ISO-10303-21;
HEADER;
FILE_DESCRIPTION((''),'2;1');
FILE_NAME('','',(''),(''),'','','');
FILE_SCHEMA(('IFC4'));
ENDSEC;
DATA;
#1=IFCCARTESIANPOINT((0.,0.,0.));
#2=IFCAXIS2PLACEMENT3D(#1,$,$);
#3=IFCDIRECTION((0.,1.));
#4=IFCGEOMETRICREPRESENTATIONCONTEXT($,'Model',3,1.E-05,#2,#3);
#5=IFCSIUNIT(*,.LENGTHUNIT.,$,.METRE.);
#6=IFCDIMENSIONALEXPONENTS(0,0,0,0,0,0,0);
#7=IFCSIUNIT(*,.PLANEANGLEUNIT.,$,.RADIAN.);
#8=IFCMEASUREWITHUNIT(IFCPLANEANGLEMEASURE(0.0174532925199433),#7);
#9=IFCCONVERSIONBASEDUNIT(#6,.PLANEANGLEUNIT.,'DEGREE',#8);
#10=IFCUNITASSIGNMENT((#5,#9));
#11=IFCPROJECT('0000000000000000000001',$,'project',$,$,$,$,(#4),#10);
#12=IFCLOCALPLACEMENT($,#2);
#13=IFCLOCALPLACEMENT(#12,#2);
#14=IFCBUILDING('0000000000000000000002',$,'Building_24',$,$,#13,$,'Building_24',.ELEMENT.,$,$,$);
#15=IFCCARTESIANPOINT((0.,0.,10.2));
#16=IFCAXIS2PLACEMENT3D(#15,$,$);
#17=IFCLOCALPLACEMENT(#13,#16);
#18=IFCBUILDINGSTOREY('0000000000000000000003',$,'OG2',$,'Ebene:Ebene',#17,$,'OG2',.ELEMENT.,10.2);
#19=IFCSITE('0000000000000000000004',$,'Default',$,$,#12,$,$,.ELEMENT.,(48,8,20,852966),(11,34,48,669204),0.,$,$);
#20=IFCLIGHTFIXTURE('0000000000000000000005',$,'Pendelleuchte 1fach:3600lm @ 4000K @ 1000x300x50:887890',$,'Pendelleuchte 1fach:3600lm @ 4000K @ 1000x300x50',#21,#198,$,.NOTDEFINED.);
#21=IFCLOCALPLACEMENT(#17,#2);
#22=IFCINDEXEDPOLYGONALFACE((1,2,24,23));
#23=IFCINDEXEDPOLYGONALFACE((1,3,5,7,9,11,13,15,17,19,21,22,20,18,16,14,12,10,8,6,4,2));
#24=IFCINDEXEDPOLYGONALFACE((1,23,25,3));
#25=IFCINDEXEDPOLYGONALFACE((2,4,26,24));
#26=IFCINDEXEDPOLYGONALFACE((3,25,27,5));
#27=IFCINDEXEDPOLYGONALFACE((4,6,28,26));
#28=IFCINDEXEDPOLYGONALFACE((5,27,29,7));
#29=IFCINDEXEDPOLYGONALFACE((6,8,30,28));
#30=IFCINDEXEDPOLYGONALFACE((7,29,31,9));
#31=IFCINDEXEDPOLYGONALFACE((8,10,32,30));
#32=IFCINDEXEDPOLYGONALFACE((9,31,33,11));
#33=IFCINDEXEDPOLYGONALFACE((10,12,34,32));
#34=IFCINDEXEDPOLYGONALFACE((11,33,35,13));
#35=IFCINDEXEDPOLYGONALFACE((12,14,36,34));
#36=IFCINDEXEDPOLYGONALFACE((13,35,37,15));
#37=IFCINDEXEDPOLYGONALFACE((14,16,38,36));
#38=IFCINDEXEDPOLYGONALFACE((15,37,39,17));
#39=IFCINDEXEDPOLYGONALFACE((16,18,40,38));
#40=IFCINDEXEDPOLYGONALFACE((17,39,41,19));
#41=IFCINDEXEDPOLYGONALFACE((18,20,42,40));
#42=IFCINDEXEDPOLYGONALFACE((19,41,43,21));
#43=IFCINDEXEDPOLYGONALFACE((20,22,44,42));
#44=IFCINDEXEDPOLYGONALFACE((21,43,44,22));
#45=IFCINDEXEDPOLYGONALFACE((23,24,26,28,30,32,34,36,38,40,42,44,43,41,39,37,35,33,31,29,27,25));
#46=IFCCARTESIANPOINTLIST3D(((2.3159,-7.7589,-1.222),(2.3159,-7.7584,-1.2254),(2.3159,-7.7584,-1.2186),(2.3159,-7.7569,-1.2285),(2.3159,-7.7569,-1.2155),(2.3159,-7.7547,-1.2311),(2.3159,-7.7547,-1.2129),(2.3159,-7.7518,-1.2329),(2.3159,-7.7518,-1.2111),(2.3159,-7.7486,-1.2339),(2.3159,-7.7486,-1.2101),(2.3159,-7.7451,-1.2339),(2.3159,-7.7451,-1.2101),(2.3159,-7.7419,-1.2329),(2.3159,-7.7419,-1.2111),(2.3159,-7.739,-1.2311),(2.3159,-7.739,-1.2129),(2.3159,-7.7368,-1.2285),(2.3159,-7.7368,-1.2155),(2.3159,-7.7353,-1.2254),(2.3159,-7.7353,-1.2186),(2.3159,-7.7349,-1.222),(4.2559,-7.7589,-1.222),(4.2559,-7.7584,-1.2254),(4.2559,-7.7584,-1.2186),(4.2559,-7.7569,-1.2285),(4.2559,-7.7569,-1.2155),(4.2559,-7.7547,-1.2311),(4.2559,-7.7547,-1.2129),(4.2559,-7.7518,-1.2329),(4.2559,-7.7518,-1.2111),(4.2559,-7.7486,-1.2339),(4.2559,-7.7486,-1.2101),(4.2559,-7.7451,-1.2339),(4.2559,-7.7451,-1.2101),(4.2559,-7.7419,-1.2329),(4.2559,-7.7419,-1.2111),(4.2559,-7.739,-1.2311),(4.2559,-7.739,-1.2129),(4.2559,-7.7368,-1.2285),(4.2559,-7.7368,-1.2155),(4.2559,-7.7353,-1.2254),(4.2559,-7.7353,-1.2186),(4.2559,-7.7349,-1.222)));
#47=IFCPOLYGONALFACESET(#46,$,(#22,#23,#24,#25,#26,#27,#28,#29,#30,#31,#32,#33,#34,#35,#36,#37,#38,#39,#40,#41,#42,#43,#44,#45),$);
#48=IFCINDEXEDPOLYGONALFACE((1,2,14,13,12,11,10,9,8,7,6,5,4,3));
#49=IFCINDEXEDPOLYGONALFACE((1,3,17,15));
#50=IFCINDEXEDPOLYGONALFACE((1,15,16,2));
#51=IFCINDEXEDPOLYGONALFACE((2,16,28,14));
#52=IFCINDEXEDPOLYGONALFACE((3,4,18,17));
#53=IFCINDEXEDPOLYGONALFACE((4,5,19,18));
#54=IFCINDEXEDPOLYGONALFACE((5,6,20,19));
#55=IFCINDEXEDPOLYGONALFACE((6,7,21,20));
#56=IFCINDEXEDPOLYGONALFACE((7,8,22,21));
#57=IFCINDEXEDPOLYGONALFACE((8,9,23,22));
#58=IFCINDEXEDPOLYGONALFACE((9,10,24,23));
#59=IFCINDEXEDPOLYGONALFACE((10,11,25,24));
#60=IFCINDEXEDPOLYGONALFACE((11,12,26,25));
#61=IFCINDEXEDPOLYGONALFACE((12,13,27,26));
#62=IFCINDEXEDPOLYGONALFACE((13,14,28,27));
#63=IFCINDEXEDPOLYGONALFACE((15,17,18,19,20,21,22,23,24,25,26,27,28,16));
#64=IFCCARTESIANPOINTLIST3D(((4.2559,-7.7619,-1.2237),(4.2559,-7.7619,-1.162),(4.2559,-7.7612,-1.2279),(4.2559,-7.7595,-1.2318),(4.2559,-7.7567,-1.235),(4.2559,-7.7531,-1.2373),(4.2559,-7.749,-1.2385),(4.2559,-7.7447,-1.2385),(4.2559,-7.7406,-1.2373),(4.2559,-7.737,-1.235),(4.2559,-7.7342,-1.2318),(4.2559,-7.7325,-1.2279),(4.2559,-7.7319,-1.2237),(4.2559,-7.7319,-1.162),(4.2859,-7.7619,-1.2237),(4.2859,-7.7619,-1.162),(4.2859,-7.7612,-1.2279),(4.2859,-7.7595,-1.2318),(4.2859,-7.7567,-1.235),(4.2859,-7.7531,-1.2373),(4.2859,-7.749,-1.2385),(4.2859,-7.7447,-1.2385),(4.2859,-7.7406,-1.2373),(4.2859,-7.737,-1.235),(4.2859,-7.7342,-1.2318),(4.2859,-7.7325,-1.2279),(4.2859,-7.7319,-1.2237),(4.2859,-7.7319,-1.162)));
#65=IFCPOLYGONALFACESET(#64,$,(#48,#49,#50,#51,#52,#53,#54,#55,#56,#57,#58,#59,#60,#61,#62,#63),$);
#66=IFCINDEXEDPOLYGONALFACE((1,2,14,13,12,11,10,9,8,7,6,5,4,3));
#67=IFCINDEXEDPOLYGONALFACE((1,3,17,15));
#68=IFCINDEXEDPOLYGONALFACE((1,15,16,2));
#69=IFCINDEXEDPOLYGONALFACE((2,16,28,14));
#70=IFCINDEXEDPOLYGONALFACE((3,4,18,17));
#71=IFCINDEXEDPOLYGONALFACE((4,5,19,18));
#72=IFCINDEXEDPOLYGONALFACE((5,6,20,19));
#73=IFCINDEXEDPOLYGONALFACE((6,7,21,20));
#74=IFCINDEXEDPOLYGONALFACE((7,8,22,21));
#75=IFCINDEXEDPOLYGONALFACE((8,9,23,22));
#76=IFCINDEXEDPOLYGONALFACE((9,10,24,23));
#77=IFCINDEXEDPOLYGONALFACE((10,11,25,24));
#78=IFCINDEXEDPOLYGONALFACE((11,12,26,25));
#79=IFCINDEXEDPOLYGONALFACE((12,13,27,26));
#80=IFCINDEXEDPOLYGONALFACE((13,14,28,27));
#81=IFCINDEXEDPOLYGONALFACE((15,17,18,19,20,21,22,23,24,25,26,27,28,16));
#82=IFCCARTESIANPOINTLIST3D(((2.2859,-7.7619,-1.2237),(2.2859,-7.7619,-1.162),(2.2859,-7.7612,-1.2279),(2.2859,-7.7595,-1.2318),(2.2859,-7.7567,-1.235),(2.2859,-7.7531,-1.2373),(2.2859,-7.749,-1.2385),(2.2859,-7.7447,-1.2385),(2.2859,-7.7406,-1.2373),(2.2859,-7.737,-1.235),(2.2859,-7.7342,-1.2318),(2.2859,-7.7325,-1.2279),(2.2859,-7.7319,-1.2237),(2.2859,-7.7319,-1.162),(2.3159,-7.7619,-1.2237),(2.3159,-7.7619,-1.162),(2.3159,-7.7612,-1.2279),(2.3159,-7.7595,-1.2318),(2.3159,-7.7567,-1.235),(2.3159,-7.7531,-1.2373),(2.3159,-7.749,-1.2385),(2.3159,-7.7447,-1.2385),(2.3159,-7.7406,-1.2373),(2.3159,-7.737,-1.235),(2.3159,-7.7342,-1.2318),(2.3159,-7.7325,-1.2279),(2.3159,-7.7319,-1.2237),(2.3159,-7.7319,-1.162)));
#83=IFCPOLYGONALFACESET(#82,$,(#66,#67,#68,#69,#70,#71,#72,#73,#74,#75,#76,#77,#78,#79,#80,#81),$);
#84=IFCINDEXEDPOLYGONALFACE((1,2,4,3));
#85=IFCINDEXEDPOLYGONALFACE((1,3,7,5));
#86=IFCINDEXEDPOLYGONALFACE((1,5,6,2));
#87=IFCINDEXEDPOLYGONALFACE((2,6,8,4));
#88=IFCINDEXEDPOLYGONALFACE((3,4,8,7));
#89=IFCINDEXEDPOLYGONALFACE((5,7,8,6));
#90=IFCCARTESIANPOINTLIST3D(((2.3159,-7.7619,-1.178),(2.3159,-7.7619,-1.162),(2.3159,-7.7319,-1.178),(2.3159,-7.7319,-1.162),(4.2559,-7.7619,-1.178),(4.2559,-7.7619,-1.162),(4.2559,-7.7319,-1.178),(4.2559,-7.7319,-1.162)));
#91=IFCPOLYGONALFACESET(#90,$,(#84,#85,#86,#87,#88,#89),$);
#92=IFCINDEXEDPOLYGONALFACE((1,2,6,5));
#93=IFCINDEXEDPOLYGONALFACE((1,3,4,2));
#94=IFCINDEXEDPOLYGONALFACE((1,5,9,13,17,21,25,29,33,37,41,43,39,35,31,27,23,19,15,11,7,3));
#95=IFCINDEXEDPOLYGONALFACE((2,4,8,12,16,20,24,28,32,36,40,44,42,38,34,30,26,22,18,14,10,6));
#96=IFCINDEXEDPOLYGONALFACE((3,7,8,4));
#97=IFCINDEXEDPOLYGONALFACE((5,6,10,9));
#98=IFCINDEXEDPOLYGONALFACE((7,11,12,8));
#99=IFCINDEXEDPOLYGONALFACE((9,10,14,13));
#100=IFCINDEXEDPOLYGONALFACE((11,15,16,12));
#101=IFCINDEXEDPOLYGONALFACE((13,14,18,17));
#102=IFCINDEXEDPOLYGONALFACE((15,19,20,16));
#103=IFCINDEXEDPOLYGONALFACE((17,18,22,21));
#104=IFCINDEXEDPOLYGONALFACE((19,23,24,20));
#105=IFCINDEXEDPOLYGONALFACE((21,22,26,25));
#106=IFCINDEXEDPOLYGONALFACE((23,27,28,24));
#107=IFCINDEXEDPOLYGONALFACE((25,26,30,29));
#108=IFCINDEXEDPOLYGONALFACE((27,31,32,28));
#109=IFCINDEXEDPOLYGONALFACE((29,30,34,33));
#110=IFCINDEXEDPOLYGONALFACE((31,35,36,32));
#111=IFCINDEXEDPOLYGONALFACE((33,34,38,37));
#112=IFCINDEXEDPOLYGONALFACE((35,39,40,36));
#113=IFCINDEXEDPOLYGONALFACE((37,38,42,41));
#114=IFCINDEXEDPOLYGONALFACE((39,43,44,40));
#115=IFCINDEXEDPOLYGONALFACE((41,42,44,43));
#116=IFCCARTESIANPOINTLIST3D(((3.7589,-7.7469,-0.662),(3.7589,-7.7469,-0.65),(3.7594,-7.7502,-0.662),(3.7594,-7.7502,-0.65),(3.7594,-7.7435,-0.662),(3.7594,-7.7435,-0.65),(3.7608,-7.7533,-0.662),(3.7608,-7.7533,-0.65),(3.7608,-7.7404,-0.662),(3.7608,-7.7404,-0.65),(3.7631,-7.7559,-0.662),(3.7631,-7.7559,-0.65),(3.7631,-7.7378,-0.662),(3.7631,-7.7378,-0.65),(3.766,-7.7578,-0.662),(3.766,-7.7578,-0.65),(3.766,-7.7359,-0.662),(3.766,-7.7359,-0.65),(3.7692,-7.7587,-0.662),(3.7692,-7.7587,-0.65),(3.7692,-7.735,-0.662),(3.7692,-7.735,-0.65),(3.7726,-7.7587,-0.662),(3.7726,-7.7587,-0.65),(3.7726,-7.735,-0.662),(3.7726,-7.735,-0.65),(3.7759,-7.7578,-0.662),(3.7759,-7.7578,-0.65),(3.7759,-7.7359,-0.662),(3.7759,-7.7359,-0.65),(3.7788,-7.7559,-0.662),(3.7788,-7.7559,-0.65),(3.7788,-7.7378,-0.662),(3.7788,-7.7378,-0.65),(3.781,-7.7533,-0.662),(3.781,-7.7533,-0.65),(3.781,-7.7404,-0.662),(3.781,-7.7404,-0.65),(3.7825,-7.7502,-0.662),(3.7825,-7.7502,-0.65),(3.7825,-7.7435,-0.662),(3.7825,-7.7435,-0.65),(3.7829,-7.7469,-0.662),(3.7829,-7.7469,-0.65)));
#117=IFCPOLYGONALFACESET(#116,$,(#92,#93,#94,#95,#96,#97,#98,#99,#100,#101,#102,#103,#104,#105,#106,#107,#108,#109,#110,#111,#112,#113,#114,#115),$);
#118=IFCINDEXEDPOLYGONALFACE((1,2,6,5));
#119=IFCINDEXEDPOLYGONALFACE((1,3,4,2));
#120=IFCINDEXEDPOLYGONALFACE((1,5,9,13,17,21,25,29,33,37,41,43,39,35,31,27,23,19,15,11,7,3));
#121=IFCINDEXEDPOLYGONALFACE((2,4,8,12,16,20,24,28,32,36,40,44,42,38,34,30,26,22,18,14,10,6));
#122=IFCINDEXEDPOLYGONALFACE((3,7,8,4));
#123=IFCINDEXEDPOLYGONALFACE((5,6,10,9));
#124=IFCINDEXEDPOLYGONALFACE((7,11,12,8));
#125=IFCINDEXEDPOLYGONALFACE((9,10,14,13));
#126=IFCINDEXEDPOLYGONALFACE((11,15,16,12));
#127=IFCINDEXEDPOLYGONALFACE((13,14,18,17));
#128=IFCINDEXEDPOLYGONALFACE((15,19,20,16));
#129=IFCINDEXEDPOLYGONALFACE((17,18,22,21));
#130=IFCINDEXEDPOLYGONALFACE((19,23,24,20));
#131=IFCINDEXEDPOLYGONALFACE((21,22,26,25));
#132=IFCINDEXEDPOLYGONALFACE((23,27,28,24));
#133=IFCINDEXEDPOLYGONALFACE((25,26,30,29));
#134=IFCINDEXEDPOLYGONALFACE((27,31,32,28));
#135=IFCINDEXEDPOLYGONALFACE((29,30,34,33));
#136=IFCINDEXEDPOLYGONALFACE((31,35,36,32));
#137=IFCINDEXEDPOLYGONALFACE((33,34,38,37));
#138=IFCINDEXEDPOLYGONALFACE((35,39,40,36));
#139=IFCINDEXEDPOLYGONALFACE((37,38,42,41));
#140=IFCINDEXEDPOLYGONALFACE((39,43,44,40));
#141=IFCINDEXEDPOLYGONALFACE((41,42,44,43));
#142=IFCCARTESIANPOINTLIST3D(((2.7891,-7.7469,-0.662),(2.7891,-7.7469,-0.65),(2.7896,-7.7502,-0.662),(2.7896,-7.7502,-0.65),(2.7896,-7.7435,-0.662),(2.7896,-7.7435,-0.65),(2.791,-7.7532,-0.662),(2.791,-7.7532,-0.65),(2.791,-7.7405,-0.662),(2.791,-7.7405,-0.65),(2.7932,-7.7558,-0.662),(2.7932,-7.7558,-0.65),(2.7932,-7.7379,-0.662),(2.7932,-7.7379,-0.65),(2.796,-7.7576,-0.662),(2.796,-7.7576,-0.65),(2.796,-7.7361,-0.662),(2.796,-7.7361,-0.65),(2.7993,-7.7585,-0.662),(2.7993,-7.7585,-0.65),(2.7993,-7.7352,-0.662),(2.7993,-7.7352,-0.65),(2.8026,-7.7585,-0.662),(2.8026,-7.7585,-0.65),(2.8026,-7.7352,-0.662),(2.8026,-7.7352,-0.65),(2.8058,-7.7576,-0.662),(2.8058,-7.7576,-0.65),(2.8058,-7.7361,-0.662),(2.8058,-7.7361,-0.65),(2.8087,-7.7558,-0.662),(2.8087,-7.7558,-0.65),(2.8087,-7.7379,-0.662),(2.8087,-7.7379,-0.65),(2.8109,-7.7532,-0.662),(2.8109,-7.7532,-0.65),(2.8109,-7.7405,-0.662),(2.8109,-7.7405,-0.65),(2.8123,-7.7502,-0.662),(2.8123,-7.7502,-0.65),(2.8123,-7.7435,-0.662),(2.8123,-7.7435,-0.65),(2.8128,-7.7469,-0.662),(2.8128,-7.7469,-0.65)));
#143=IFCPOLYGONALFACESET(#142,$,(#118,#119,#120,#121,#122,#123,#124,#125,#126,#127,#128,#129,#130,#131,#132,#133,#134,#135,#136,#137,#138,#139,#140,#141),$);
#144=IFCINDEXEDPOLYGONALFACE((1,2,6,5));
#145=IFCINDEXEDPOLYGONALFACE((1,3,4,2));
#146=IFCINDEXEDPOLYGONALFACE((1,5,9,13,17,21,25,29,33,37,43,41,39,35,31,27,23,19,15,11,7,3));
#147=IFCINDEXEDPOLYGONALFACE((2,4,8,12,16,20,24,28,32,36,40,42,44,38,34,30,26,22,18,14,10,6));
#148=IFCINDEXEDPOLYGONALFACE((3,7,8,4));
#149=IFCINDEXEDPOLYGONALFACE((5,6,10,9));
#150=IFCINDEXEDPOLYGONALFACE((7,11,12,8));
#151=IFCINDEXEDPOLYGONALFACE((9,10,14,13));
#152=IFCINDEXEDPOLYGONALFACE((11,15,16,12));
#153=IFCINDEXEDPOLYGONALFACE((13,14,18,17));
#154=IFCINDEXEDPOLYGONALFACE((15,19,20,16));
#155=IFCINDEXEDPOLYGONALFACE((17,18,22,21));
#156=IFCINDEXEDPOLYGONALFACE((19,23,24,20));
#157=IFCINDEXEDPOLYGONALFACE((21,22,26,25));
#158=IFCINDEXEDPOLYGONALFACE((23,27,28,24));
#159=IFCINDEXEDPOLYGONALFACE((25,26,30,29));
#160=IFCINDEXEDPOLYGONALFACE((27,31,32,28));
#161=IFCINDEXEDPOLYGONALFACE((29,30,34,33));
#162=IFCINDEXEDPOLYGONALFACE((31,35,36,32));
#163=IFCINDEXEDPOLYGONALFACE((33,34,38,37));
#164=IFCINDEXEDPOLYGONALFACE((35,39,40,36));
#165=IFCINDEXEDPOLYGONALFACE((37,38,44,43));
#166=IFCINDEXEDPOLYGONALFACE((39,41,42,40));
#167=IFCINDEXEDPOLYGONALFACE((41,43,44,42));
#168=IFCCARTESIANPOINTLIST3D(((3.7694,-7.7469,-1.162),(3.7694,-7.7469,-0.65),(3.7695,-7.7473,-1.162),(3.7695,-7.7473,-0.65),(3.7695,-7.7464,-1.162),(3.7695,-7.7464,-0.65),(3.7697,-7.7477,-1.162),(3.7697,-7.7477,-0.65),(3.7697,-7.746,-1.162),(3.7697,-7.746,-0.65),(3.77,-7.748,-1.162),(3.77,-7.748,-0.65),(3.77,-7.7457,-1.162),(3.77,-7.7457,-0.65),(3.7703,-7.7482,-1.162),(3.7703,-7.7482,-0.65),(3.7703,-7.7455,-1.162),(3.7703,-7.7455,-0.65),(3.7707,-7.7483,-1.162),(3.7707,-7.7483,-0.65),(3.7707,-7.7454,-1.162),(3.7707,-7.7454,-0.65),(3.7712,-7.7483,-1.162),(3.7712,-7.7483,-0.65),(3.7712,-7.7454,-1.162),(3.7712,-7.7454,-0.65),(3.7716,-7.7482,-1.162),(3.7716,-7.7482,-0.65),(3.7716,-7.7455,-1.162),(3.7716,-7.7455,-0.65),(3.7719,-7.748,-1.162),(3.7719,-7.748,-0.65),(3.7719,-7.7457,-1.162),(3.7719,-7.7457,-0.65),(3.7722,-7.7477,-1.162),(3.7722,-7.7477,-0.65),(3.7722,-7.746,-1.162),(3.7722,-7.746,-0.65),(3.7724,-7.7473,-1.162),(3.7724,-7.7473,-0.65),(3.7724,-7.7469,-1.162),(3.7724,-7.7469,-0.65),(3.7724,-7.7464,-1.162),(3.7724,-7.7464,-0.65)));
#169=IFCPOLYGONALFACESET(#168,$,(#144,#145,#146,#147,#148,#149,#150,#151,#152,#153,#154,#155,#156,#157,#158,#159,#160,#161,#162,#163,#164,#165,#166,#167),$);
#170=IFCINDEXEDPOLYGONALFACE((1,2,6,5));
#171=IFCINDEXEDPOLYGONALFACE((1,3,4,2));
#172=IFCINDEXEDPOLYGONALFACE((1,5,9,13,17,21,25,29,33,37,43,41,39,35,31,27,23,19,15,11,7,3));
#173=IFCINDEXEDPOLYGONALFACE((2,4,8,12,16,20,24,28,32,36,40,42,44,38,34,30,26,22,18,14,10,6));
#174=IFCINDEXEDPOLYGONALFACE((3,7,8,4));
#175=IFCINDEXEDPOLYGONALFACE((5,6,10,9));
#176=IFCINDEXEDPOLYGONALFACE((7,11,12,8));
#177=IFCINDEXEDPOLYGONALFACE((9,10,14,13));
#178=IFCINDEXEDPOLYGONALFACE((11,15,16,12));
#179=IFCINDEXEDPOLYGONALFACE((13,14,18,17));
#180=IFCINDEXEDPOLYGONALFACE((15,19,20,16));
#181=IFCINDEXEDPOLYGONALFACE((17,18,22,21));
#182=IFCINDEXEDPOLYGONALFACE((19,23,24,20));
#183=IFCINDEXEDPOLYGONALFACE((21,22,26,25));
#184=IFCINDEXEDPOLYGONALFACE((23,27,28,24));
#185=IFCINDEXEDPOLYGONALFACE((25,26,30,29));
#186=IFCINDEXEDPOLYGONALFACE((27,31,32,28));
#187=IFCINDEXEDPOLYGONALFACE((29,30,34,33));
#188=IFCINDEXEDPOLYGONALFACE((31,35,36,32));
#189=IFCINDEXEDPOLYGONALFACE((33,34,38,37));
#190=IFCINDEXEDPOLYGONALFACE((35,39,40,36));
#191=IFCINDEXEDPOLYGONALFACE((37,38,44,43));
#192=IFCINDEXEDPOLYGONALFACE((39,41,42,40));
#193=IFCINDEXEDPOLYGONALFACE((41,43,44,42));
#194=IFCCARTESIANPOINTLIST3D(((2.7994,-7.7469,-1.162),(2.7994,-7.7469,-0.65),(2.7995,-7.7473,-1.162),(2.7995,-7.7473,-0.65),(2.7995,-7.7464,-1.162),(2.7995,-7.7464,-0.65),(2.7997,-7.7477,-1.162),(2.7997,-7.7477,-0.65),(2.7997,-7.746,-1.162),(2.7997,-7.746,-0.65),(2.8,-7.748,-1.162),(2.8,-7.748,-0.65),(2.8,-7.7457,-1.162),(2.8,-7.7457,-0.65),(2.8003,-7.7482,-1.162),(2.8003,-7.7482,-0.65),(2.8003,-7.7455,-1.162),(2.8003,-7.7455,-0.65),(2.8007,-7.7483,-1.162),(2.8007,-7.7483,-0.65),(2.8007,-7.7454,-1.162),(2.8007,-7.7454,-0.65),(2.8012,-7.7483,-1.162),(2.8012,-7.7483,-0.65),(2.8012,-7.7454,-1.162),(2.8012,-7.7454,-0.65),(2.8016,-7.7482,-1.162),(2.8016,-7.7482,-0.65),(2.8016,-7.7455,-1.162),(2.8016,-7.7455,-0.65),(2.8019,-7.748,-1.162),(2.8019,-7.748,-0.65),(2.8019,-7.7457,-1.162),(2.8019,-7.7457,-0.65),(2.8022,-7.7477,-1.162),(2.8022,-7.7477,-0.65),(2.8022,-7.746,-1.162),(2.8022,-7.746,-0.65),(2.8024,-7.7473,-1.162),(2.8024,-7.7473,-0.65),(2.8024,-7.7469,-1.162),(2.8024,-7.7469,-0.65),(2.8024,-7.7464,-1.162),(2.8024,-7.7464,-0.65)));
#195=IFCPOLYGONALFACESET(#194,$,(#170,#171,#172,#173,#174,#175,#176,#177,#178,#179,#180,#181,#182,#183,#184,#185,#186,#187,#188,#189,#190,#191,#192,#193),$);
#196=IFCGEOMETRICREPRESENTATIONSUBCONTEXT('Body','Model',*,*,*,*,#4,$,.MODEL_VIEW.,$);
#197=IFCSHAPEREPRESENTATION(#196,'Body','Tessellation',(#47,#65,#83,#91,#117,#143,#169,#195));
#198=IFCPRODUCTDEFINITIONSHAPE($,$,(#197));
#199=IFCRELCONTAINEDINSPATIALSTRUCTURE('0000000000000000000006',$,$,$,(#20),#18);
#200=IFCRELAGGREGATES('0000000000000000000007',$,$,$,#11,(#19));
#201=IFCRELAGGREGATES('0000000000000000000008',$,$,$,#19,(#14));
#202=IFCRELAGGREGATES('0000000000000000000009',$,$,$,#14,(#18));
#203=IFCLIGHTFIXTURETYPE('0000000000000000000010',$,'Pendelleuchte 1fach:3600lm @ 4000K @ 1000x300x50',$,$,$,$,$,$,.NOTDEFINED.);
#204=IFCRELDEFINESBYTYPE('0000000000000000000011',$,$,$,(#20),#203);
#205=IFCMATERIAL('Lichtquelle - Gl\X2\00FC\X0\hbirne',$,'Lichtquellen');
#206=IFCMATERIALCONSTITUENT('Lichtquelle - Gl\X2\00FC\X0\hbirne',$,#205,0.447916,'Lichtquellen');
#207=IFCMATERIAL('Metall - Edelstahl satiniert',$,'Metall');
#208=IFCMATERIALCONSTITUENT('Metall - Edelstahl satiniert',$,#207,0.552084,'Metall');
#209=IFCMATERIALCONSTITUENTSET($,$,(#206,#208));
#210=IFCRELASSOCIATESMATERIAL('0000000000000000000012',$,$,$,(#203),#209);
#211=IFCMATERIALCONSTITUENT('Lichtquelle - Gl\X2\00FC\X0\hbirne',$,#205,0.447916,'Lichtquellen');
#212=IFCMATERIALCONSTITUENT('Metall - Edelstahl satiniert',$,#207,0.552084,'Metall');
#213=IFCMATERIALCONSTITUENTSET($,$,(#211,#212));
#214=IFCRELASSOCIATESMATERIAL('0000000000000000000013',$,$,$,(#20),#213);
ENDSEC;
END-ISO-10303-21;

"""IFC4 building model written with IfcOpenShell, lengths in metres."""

from ifc_helpers import new_model, entity, si_unit, converted_unit, direction, frame, origin, place, context, subcontext, project, spatial, line, arc, indexed_curve, outline, extrude, source, transform, mapped, material, constituent, constituent_set, type_object, type_shapes, element, save


model = new_model("IFC4")

# Units and contexts
model_context = context("Model", 3, precision=1e-05, world=origin(), true_north=direction((0.0, 1.0)))
body_context = subcontext(model_context, "Body", "Model", "MODEL_VIEW")
ifc_project = project(units=[si_unit("LENGTHUNIT", "METRE"), converted_unit("PLANEANGLEUNIT", "DEGREE", entity("IfcPlaneAngleMeasure", 0.0174532925199433), si_unit("PLANEANGLEUNIT", "RADIAN"), dimensions=[0, 0, 0, 0, 0, 0, 0])], contexts=[model_context])

# Site, building, storey
site_placement = place(None, origin())
site = spatial("IfcSite", under=ifc_project, at=site_placement, Name="Default", CompositionType="ELEMENT", RefLatitude=(48, 8, 20, 852966), RefLongitude=(11, 34, 48, 669204), RefElevation=0.0)
building_placement = place(site_placement, origin())
building = spatial("IfcBuilding", under=site, at=building_placement, Name="Building_24", LongName="Building_24", CompositionType="ELEMENT")
storey_placement = place(building_placement, frame((0.0, 0.0, 10.2)))
storey = spatial("IfcBuildingStorey", under=building, at=storey_placement, Name="OG2", ObjectType="Ebene:Ebene", LongName="OG2", CompositionType="ELEMENT", Elevation=10.2)

# Light fixture
ifc_material_1 = material(Name="Lichtquelle - Glühbirne", Category="Lichtquellen")
ifc_material_2 = material(Name="Metall - Edelstahl satiniert", Category="Metall")
ifc_constituent_1 = constituent(ifc_material_1, Name="Lichtquelle - Glühbirne", Category="Lichtquellen", fraction=0.447916)
ifc_constituent_2 = constituent(ifc_material_2, Name="Metall - Edelstahl satiniert", Category="Metall", fraction=0.552084)
ifc_constituent_set_1 = constituent_set(constituents=[ifc_constituent_1, ifc_constituent_2])
light_fixture_type_1 = type_object("IfcLightFixtureType", Name="Pendelleuchte 1fach:3600lm @ 4000K @ 1000x300x50", PredefinedType="NOTDEFINED", material=ifc_constituent_set_1)
shared_shape_1 = source(origin(), body_context, "Body", "SweptSolid", [
    extrude(outline(indexed_curve([(-0.012, 0.0), (0.0, -0.012), (0.012, 0.0), (0.0, 0.012)], segments=[arc(1, 2, 3), arc(3, 4, 1)], self_intersect=False)), frame((-0.97, 0.0, -0.572), z_axis=(1.0, 0.0, 0.0), x_axis=(0.0, 1.0, 0.0)), (0.0, 0.0, 1.0), 1.94),
    extrude(outline(indexed_curve([(-0.0308, -0.015), (0.0308, -0.015), (0.0308, 0.015), (-0.0308, 0.015), (-0.0458, 0.0)], segments=[line(1, 2, 3, 4), arc(4, 5, 1)], self_intersect=False)), frame((0.97, 0.0, -0.5428), z_axis=(1.0, 0.0, 0.0), x_axis=(0.0, 0.0, 1.0)), (0.0, 0.0, 1.0), 0.03),
    extrude(outline(indexed_curve([(-0.0308, -0.015), (0.0308, -0.015), (0.0308, 0.015), (-0.0308, 0.015), (-0.0458, 0.0)], segments=[line(1, 2, 3, 4), arc(4, 5, 1)], self_intersect=False)), frame((-1.0, 0.0, -0.5428), z_axis=(1.0, 0.0, 0.0), x_axis=(0.0, 0.0, 1.0)), (0.0, 0.0, 1.0), 0.03),
    extrude(outline(indexed_curve([(-0.97, -0.015), (0.97, -0.015), (0.97, 0.015), (-0.97, 0.015), (-0.97, -0.015)], self_intersect=False)), frame((0.0, 0.0, -0.528), z_axis=(0.0, 0.0, 1.0), x_axis=(-1.0, 0.0, 0.0)), (0.0, 0.0, 1.0), 0.016),
    extrude(outline(indexed_curve([(-0.012, 0.0), (0.0, -0.012), (0.012, 0.0), (0.0, 0.012)], segments=[arc(1, 2, 3), arc(3, 4, 1)], self_intersect=False)), frame((0.485, 0.0, -0.012)), (0.0, 0.0, 1.0), 0.012),
    extrude(outline(indexed_curve([(-0.0118, 0.0), (0.0, -0.0118), (0.0118, 0.0), (0.0, 0.0118)], segments=[arc(1, 2, 3), arc(3, 4, 1)], self_intersect=False)), frame((-0.485, 0.0, -0.012)), (0.0, 0.0, 1.0), 0.012),
    extrude(outline(indexed_curve([(-0.0015, 0.0), (0.0, -0.0015), (0.0015, 0.0), (0.0, 0.0015)], segments=[arc(1, 2, 3), arc(3, 4, 1)], self_intersect=False)), frame((0.485, 0.0, -0.512)), (0.0, 0.0, 1.0), 0.512),
    extrude(outline(indexed_curve([(-0.0015, 0.0), (0.0, -0.0015), (0.0015, 0.0), (0.0, 0.0015)], segments=[arc(1, 2, 3), arc(3, 4, 1)], self_intersect=False)), frame((-0.485, 0.0, -0.512)), (0.0, 0.0, 1.0), 0.512),
])
type_shapes(light_fixture_type_1, [shared_shape_1])
ifc_constituent_3 = constituent(ifc_material_1, Name="Lichtquelle - Glühbirne", Category="Lichtquellen", fraction=0.447916)
ifc_constituent_4 = constituent(ifc_material_2, Name="Metall - Edelstahl satiniert", Category="Metall", fraction=0.552084)
ifc_constituent_set_2 = constituent_set(constituents=[ifc_constituent_3, ifc_constituent_4])
light_fixture_1_placement = place(storey_placement, frame((3.2859, -7.7469, -0.65)))
element("IfcLightFixture", 1, at=light_fixture_1_placement, inside=storey, type_object=light_fixture_type_1, material=ifc_constituent_set_2, Name="Pendelleuchte 1fach:3600lm @ 4000K @ 1000x300x50:887890", ObjectType="Pendelleuchte 1fach:3600lm @ 4000K @ 1000x300x50", PredefinedType="NOTDEFINED", context=body_context, shape_type="MappedRepresentation", body=[
    mapped(shared_shape_1, transform((0.0, 0.0, 0.0), scale=1.0)),
])

save(model, "model.ifc")
